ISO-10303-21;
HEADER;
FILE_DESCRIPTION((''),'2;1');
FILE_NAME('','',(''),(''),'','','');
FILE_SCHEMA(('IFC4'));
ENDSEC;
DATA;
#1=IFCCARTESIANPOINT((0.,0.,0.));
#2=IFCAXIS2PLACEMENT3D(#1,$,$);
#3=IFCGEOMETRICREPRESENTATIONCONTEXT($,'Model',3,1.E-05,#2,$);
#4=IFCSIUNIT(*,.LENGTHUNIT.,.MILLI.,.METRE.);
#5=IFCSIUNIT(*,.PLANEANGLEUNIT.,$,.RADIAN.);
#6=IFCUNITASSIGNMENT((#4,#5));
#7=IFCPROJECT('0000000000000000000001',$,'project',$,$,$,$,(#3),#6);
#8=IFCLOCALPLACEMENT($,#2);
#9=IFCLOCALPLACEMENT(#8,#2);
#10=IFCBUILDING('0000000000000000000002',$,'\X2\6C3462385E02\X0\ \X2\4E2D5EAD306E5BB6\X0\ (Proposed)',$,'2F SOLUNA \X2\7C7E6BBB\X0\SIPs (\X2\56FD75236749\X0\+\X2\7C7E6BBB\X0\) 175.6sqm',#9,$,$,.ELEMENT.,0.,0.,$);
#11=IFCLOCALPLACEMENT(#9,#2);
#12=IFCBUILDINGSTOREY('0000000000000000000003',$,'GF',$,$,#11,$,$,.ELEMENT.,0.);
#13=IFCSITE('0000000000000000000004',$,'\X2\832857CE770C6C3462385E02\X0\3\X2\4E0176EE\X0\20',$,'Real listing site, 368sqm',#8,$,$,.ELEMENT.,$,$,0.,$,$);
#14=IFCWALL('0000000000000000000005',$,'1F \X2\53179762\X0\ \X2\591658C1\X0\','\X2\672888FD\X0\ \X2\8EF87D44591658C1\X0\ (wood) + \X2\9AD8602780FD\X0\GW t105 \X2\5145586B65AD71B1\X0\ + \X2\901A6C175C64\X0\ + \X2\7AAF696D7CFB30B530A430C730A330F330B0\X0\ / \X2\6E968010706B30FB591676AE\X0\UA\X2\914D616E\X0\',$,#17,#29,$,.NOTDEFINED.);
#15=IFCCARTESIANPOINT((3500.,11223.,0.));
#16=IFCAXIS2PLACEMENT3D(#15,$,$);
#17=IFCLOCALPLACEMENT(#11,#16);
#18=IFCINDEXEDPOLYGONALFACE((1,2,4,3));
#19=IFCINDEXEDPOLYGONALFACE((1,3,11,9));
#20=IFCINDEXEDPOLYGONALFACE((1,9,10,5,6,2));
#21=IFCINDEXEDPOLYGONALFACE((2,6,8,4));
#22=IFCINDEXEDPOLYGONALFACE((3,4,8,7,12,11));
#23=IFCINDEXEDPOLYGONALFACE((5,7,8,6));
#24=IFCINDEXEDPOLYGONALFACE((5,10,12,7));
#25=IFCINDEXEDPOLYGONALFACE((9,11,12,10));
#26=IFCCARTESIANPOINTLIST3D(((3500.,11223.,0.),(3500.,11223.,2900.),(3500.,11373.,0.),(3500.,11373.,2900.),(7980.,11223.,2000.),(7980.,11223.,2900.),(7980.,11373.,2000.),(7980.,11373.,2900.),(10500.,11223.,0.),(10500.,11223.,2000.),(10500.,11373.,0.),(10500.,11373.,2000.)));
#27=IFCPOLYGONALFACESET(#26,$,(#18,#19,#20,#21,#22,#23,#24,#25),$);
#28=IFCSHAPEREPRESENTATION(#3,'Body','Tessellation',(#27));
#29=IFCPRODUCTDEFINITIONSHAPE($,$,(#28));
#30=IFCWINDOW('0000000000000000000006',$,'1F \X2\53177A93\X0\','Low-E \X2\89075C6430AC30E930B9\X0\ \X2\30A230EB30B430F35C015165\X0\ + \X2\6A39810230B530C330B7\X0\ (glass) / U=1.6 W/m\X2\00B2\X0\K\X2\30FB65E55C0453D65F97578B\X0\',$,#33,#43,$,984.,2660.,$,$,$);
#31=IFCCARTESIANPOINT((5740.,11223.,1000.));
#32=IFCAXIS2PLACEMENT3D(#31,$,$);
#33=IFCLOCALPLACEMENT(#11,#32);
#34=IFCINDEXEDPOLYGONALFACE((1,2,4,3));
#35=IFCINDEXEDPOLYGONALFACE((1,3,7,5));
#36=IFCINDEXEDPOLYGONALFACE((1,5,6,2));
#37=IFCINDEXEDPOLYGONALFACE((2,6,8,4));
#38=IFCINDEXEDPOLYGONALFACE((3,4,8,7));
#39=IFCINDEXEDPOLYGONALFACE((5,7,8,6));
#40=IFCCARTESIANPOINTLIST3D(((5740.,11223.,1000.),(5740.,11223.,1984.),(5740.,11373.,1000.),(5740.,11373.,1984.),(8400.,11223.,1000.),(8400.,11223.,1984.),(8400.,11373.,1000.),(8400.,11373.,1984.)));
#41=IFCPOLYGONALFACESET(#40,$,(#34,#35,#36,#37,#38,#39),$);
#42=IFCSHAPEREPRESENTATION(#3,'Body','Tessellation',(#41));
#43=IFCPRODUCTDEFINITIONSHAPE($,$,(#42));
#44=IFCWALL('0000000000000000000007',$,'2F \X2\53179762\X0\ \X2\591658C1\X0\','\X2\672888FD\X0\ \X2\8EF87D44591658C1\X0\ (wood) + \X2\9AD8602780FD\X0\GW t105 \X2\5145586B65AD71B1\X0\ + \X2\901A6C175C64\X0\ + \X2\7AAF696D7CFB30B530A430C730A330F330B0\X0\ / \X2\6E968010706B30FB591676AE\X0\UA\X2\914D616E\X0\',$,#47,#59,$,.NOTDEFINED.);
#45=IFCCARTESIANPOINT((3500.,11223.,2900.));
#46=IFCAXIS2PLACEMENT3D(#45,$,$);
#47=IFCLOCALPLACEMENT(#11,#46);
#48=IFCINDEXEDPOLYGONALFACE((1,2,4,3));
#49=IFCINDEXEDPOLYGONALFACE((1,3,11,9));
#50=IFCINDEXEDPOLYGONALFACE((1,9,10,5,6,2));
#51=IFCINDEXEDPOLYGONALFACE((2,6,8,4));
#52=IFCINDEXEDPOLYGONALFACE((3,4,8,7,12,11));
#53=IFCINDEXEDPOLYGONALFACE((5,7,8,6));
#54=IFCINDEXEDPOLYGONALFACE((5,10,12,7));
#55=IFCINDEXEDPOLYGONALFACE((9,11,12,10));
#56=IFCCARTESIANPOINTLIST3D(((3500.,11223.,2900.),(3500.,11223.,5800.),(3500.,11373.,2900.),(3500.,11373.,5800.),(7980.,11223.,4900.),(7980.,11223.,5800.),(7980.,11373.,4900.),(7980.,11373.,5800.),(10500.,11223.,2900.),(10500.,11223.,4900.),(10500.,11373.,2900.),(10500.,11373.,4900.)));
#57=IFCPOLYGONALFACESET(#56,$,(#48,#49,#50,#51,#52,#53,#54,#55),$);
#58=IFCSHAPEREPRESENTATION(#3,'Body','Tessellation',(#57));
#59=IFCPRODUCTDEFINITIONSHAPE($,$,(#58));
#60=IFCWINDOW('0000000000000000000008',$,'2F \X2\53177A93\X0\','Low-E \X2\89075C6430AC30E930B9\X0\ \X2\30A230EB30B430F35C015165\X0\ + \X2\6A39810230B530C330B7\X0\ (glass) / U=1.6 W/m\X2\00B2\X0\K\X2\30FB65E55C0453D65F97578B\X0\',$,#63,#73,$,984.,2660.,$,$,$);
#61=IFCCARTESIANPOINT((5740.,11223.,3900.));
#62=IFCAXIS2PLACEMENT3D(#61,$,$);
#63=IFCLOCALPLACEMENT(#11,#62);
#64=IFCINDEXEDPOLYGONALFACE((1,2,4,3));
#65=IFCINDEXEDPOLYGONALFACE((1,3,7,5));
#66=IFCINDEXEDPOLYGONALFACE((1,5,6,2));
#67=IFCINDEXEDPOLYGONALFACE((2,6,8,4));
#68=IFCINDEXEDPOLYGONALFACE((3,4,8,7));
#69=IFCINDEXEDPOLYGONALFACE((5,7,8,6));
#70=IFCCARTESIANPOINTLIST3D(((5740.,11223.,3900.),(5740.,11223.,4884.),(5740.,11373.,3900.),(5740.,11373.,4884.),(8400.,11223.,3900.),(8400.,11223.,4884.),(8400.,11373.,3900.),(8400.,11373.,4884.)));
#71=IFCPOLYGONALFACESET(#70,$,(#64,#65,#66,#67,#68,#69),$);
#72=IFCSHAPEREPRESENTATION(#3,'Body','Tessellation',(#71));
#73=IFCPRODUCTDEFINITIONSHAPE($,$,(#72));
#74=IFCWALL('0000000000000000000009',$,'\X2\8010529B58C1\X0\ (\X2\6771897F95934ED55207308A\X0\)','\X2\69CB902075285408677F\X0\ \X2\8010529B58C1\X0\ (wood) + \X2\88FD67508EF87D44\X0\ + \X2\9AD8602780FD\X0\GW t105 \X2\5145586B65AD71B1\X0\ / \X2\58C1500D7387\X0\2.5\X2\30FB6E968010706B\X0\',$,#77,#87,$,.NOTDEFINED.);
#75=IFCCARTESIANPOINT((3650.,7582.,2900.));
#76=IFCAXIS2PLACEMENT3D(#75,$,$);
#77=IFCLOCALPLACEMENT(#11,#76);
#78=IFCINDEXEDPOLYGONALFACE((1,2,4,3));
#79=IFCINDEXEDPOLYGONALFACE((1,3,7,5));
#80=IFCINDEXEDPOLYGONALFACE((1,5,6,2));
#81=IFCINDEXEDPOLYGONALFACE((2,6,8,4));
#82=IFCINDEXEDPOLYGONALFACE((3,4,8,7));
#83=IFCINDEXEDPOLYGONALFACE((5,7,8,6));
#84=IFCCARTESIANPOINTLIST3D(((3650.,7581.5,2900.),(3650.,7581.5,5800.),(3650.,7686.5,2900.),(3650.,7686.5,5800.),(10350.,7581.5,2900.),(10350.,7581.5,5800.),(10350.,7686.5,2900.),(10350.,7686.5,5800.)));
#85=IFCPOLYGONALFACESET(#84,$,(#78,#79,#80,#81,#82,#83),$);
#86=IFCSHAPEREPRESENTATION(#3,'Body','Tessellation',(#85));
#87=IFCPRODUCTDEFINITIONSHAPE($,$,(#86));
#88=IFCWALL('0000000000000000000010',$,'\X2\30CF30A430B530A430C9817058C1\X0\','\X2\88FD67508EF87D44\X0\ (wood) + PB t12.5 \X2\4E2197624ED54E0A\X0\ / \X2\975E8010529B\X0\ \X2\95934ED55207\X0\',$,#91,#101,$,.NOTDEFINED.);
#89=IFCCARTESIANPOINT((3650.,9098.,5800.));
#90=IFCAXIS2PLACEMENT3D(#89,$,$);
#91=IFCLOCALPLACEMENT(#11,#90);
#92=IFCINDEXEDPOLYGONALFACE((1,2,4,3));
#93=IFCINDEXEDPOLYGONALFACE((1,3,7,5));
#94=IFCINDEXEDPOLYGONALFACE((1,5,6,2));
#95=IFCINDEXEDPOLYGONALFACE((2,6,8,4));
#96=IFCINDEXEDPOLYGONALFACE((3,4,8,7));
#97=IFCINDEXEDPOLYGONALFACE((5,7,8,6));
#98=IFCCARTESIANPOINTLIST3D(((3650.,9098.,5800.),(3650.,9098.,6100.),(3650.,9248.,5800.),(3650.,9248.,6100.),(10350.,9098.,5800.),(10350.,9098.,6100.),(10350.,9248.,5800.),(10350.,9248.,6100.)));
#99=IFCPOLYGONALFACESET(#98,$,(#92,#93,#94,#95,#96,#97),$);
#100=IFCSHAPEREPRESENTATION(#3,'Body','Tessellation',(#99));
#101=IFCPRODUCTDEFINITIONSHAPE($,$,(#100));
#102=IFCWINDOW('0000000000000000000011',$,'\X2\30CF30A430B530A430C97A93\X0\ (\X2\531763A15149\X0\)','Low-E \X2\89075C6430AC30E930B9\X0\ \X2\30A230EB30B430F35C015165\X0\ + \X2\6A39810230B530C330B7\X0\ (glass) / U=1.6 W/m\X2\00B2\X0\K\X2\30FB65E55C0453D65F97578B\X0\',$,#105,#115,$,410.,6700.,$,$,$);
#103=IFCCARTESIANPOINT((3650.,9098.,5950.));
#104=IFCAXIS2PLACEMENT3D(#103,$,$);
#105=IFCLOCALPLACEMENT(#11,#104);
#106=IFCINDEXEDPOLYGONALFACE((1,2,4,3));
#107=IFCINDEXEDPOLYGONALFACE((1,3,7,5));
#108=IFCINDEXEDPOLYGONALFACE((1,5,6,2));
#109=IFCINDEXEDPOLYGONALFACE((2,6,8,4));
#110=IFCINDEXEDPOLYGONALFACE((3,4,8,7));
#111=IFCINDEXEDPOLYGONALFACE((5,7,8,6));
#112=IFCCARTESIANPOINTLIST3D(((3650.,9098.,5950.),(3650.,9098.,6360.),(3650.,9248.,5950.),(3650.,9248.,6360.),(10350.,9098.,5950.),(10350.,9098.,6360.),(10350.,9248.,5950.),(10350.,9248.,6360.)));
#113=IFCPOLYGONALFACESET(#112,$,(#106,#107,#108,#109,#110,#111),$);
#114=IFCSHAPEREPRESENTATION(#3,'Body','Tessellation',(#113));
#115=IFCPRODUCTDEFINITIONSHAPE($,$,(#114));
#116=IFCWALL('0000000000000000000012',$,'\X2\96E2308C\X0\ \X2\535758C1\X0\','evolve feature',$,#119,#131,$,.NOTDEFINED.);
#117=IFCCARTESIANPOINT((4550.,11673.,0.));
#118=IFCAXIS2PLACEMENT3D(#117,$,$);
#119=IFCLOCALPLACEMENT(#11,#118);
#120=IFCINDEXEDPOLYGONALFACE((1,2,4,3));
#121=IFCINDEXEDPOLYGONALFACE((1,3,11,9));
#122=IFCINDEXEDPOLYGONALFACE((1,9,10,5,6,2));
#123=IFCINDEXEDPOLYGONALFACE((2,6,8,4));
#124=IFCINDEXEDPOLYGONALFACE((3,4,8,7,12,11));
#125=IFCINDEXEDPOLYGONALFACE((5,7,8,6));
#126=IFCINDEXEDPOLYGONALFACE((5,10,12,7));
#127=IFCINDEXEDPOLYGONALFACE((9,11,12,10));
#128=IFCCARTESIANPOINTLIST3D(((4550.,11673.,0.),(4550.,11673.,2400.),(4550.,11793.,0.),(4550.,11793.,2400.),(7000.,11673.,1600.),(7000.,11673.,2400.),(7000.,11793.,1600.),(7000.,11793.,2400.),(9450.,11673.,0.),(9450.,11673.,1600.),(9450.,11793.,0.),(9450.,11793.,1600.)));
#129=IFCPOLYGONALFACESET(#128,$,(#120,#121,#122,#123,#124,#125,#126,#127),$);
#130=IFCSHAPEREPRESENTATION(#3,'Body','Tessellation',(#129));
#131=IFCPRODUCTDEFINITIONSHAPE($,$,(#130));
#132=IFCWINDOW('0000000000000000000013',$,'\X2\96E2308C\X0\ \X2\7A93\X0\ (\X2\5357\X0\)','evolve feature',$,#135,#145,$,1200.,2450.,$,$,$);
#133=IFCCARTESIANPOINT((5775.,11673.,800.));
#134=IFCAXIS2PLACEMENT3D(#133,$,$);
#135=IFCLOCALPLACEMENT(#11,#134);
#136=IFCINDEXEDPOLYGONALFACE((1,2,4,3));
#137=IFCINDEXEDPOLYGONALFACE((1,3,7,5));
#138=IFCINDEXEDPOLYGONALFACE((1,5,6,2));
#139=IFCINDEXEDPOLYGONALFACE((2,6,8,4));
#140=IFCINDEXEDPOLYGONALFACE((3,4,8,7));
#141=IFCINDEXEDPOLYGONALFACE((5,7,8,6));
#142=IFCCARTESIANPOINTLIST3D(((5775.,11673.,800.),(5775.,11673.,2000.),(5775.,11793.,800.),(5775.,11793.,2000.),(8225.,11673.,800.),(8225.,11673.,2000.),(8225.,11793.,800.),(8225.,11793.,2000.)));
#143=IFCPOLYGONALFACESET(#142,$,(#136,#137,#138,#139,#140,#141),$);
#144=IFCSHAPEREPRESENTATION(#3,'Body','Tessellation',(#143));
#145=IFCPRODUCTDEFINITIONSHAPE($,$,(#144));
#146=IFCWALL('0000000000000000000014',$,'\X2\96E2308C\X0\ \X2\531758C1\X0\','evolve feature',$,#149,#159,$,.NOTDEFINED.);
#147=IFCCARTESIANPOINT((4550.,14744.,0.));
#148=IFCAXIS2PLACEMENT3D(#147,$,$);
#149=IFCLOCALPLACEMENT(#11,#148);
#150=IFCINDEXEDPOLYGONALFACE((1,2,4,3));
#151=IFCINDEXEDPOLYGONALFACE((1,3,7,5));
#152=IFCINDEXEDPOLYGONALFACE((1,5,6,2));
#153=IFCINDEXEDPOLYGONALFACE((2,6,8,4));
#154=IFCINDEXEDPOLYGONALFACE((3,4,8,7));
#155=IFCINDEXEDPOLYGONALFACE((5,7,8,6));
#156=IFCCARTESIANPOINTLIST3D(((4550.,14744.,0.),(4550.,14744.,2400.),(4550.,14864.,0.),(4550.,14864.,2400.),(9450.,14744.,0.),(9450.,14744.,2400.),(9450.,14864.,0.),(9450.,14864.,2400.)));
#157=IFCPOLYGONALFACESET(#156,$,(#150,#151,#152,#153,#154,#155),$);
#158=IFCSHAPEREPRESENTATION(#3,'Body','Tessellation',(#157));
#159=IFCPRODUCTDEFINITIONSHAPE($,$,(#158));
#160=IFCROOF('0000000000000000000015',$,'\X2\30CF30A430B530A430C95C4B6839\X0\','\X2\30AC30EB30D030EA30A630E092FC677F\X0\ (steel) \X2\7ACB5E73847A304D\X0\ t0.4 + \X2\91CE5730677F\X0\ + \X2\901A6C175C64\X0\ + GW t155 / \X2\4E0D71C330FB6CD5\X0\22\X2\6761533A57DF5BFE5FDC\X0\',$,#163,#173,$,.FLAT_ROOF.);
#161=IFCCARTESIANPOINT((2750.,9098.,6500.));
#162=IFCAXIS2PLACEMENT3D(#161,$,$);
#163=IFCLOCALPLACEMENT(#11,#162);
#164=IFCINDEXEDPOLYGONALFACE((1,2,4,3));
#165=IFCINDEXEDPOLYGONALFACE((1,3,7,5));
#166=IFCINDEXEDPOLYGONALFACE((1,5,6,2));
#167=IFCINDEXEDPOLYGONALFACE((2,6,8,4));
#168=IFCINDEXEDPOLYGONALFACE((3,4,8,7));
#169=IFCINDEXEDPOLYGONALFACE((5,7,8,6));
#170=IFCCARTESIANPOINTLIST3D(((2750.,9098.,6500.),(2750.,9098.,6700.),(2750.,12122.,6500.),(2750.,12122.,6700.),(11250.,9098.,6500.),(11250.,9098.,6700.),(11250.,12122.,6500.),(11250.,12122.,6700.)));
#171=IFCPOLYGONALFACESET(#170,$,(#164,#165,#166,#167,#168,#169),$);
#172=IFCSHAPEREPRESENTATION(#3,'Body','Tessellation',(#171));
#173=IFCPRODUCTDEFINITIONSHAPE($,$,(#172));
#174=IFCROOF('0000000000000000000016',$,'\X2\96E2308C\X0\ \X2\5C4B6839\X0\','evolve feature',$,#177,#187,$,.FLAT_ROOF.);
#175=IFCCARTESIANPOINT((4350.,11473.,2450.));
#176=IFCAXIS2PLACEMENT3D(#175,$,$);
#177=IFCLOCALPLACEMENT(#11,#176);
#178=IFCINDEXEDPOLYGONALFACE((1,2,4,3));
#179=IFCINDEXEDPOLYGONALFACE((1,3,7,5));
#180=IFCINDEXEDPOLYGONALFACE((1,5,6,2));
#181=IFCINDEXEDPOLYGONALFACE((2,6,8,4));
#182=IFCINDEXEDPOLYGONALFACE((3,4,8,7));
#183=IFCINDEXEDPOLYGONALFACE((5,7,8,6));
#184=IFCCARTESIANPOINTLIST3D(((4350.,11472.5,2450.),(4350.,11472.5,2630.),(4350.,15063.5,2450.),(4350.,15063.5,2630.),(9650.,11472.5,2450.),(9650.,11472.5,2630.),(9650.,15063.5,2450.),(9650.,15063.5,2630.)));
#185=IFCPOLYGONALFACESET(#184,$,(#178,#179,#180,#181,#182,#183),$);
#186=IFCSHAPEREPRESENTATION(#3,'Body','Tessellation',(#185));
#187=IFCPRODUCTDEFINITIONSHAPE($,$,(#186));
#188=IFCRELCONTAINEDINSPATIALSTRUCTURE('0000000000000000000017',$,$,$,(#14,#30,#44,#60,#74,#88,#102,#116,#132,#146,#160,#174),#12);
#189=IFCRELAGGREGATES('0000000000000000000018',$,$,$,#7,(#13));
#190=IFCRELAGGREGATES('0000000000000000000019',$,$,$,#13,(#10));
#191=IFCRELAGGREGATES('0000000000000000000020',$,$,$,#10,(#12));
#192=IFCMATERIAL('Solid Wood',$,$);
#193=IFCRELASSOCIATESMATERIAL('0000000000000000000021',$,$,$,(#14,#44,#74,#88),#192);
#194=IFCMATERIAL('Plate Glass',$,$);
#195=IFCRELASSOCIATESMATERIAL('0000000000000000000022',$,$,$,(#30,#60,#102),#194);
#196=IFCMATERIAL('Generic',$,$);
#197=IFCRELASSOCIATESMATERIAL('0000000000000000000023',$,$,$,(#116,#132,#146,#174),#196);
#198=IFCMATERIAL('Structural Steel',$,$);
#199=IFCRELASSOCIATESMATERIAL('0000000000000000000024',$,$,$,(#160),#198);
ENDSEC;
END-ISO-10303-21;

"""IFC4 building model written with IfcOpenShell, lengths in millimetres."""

from ifc_helpers import new_model, si_unit, frame, frame_2d, origin, place, context, project, spatial, rectangle, extrude, material, element, fill, save


model = new_model("IFC4")

# Units and contexts
model_context = context("Model", 3, precision=1e-05, world=origin())
ifc_project = project(units=[si_unit("LENGTHUNIT", "METRE", prefix="MILLI"), si_unit("PLANEANGLEUNIT", "RADIAN")], contexts=[model_context])

# Site, building, storey
site_placement = place(None, origin())
site = spatial("IfcSite", under=ifc_project, at=site_placement, Name="茨城県水戸市3丁目20", ObjectType="Real listing site, 368sqm", CompositionType="ELEMENT", RefElevation=0.0)
building_placement = place(site_placement, origin())
building = spatial("IfcBuilding", under=site, at=building_placement, Name="水戸市 中庭の家 (Proposed)", ObjectType="2F SOLUNA 籾殻SIPs (国産杉+籾殻) 175.6sqm", CompositionType="ELEMENT", ElevationOfRefHeight=0.0, ElevationOfTerrain=0.0)
storey_placement = place(building_placement, origin())
storey = spatial("IfcBuildingStorey", under=building, at=storey_placement, Name="GF", CompositionType="ELEMENT", Elevation=0.0)

# Shared definitions
ifc_material_1 = material(Name="Generic")

# Wall, opening, window
ifc_material_2 = material(Name="Solid Wood")
wall_1_placement = place(storey_placement, frame((3500.0, 11223.0, 0.0)))
wall_1 = element("IfcWall", 1, at=wall_1_placement, inside=storey, material=ifc_material_2, Name="1F 北面 外壁", Description="木製 軸組外壁 (wood) + 高性能GW t105 充填断熱 + 通気層 + 窯業系サイディング / 準耐火・外皮UA配慮", PredefinedType="NOTDEFINED", context=model_context, shape_type="SweptSolid", body=[
    extrude(rectangle(XDim=7000.0, YDim=150.0, at=frame_2d((3500.0, 75.0))), frame((3500.0, 11223.0, 0.0)), (0.0, 0.0, 1.0), 2900.0),
])
opening_1_placement = place(storey_placement, frame((5740.0, 11223.0, 1000.0)))
opening_1 = element("IfcOpeningElement", 2, at=opening_1_placement, cuts=wall_1, PredefinedType="NOTDEFINED", context=model_context, shape_type="SweptSolid", body=[
    extrude(rectangle(XDim=2660.0, YDim=150.0, at=frame_2d((1330.0, 75.0))), frame((5740.0, 11223.0, 1000.0)), (0.0, 0.0, 1.0), 984.0),
])
ifc_material_3 = material(Name="Plate Glass")
window_1_placement = place(storey_placement, frame((5740.0, 11223.0, 1000.0)))
window_1 = element("IfcWindow", 3, at=window_1_placement, inside=storey, material=ifc_material_3, Name="1F 北窓", Description="Low-E 複層ガラス アルゴン封入 + 樹脂サッシ (glass) / U=1.6 W/m²K・日射取得型", OverallHeight=984.0, OverallWidth=2660.0, context=model_context, shape_type="SweptSolid", body=[
    extrude(rectangle(XDim=2660.0, YDim=150.0, at=frame_2d((1330.0, 75.0))), frame((5740.0, 11223.0, 1000.0)), (0.0, 0.0, 1.0), 984.0),
])
fill(opening_1, window_1)

# Wall, opening, window
wall_2_placement = place(storey_placement, frame((3500.0, 11223.0, 2900.0)))
wall_2 = element("IfcWall", 4, at=wall_2_placement, inside=storey, material=ifc_material_2, Name="2F 北面 外壁", Description="木製 軸組外壁 (wood) + 高性能GW t105 充填断熱 + 通気層 + 窯業系サイディング / 準耐火・外皮UA配慮", PredefinedType="NOTDEFINED", context=model_context, shape_type="SweptSolid", body=[
    extrude(rectangle(XDim=7000.0, YDim=150.0, at=frame_2d((3500.0, 75.0))), frame((3500.0, 11223.0, 2900.0)), (0.0, 0.0, 1.0), 2900.0),
])
opening_2_placement = place(storey_placement, frame((5740.0, 11223.0, 3900.0)))
opening_2 = element("IfcOpeningElement", 5, at=opening_2_placement, cuts=wall_2, PredefinedType="NOTDEFINED", context=model_context, shape_type="SweptSolid", body=[
    extrude(rectangle(XDim=2660.0, YDim=150.0, at=frame_2d((1330.0, 75.0))), frame((5740.0, 11223.0, 3900.0)), (0.0, 0.0, 1.0), 984.0),
])
window_2_placement = place(storey_placement, frame((5740.0, 11223.0, 3900.0)))
window_2 = element("IfcWindow", 6, at=window_2_placement, inside=storey, material=ifc_material_3, Name="2F 北窓", Description="Low-E 複層ガラス アルゴン封入 + 樹脂サッシ (glass) / U=1.6 W/m²K・日射取得型", OverallHeight=984.0, OverallWidth=2660.0, context=model_context, shape_type="SweptSolid", body=[
    extrude(rectangle(XDim=2660.0, YDim=150.0, at=frame_2d((1330.0, 75.0))), frame((5740.0, 11223.0, 3900.0)), (0.0, 0.0, 1.0), 984.0),
])
fill(opening_2, window_2)

# Wall
wall_3_placement = place(storey_placement, frame((3650.0, 7582.0, 2900.0)))
element("IfcWall", 7, at=wall_3_placement, inside=storey, material=ifc_material_2, Name="耐力壁 (東西間仕切り)", Description="構造用合板 耐力壁 (wood) + 製材軸組 + 高性能GW t105 充填断熱 / 壁倍率2.5・準耐火", PredefinedType="NOTDEFINED", context=model_context, shape_type="SweptSolid", body=[
    extrude(rectangle(XDim=6700.0, YDim=105.0, at=frame_2d((3350.0, 52.0))), frame((3650.0, 7582.0, 2900.0)), (0.0, 0.0, 1.0), 2900.0),
])

# Walls, openings, windows
wall_4_placement = place(storey_placement, frame((3650.0, 9098.0, 5800.0)))
wall_4 = element("IfcWall", 8, at=wall_4_placement, inside=storey, material=ifc_material_2, Name="ハイサイド腰壁", Description="製材軸組 (wood) + PB t12.5 両面仕上 / 非耐力 間仕切", PredefinedType="NOTDEFINED", context=model_context, shape_type="SweptSolid", body=[
    extrude(rectangle(XDim=6700.0, YDim=150.0, at=frame_2d((3350.0, 75.0))), frame((3650.0, 9098.0, 5800.0)), (0.0, 0.0, 1.0), 700.0),
])
opening_3_placement = place(storey_placement, frame((3650.0, 9098.0, 5950.0)))
opening_3 = element("IfcOpeningElement", 9, at=opening_3_placement, cuts=wall_4, PredefinedType="NOTDEFINED", context=model_context, shape_type="SweptSolid", body=[
    extrude(rectangle(XDim=6700.0, YDim=150.0, at=frame_2d((3350.0, 75.0))), frame((3650.0, 9098.0, 5950.0)), (0.0, 0.0, 1.0), 410.0),
])
window_3_placement = place(storey_placement, frame((3650.0, 9098.0, 5950.0)))
window_3 = element("IfcWindow", 10, at=window_3_placement, inside=storey, material=ifc_material_3, Name="ハイサイド窓 (北採光)", Description="Low-E 複層ガラス アルゴン封入 + 樹脂サッシ (glass) / U=1.6 W/m²K・日射取得型", OverallHeight=410.0, OverallWidth=6700.0, context=model_context, shape_type="SweptSolid", body=[
    extrude(rectangle(XDim=6700.0, YDim=150.0, at=frame_2d((3350.0, 75.0))), frame((3650.0, 9098.0, 5950.0)), (0.0, 0.0, 1.0), 410.0),
])
fill(opening_3, window_3)
wall_5_placement = place(storey_placement, frame((4550.0, 11673.0, 0.0)))
wall_5 = element("IfcWall", 11, at=wall_5_placement, inside=storey, material=ifc_material_1, Name="離れ 南壁", Description="evolve feature", PredefinedType="NOTDEFINED", context=model_context, shape_type="SweptSolid", body=[
    extrude(rectangle(XDim=4900.0, YDim=120.0, at=frame_2d((2450.0, 60.0))), frame((4550.0, 11673.0, 0.0)), (0.0, 0.0, 1.0), 2400.0),
])
opening_4_placement = place(storey_placement, frame((5775.0, 11673.0, 800.0)))
opening_4 = element("IfcOpeningElement", 12, at=opening_4_placement, cuts=wall_5, PredefinedType="NOTDEFINED", context=model_context, shape_type="SweptSolid", body=[
    extrude(rectangle(XDim=2450.0, YDim=120.0, at=frame_2d((1225.0, 60.0))), frame((5775.0, 11673.0, 800.0)), (0.0, 0.0, 1.0), 1200.0),
])
window_4_placement = place(storey_placement, frame((5775.0, 11673.0, 800.0)))
window_4 = element("IfcWindow", 13, at=window_4_placement, inside=storey, material=ifc_material_1, Name="離れ 窓 (南)", Description="evolve feature", OverallHeight=1200.0, OverallWidth=2450.0, context=model_context, shape_type="SweptSolid", body=[
    extrude(rectangle(XDim=2450.0, YDim=120.0, at=frame_2d((1225.0, 60.0))), frame((5775.0, 11673.0, 800.0)), (0.0, 0.0, 1.0), 1200.0),
])
fill(opening_4, window_4)

# Wall
wall_6_placement = place(storey_placement, frame((4550.0, 14744.0, 0.0)))
element("IfcWall", 14, at=wall_6_placement, inside=storey, material=ifc_material_1, Name="離れ 北壁", Description="evolve feature", PredefinedType="NOTDEFINED", context=model_context, shape_type="SweptSolid", body=[
    extrude(rectangle(XDim=4900.0, YDim=120.0, at=frame_2d((2450.0, 60.0))), frame((4550.0, 14744.0, 0.0)), (0.0, 0.0, 1.0), 2400.0),
])

# Roofs
ifc_material_4 = material(Name="Structural Steel")
roof_1_placement = place(storey_placement, frame((2750.0, 9098.0, 6500.0)))
element("IfcRoof", 15, at=roof_1_placement, inside=storey, material=ifc_material_4, Name="ハイサイド屋根", Description="ガルバリウム鋼板 (steel) 立平葺き t0.4 + 野地板 + 通気層 + GW t155 / 不燃・法22条区域対応", PredefinedType="FLAT_ROOF", context=model_context, shape_type="SweptSolid", body=[
    extrude(rectangle(XDim=8500.0, YDim=3024.0, at=frame_2d((4250.0, 1512.0))), frame((2750.0, 9098.0, 6500.0)), (0.0, 0.0, 1.0), 200.0),
])
roof_2_placement = place(storey_placement, frame((4350.0, 11473.0, 2450.0)))
element("IfcRoof", 16, at=roof_2_placement, inside=storey, material=ifc_material_1, Name="離れ 屋根", Description="evolve feature", PredefinedType="FLAT_ROOF", context=model_context, shape_type="SweptSolid", body=[
    extrude(rectangle(XDim=5300.0, YDim=3591.0, at=frame_2d((2650.0, 1795.0))), frame((4350.0, 11473.0, 2450.0)), (0.0, 0.0, 1.0), 180.0),
])

save(model, "model.ifc")
